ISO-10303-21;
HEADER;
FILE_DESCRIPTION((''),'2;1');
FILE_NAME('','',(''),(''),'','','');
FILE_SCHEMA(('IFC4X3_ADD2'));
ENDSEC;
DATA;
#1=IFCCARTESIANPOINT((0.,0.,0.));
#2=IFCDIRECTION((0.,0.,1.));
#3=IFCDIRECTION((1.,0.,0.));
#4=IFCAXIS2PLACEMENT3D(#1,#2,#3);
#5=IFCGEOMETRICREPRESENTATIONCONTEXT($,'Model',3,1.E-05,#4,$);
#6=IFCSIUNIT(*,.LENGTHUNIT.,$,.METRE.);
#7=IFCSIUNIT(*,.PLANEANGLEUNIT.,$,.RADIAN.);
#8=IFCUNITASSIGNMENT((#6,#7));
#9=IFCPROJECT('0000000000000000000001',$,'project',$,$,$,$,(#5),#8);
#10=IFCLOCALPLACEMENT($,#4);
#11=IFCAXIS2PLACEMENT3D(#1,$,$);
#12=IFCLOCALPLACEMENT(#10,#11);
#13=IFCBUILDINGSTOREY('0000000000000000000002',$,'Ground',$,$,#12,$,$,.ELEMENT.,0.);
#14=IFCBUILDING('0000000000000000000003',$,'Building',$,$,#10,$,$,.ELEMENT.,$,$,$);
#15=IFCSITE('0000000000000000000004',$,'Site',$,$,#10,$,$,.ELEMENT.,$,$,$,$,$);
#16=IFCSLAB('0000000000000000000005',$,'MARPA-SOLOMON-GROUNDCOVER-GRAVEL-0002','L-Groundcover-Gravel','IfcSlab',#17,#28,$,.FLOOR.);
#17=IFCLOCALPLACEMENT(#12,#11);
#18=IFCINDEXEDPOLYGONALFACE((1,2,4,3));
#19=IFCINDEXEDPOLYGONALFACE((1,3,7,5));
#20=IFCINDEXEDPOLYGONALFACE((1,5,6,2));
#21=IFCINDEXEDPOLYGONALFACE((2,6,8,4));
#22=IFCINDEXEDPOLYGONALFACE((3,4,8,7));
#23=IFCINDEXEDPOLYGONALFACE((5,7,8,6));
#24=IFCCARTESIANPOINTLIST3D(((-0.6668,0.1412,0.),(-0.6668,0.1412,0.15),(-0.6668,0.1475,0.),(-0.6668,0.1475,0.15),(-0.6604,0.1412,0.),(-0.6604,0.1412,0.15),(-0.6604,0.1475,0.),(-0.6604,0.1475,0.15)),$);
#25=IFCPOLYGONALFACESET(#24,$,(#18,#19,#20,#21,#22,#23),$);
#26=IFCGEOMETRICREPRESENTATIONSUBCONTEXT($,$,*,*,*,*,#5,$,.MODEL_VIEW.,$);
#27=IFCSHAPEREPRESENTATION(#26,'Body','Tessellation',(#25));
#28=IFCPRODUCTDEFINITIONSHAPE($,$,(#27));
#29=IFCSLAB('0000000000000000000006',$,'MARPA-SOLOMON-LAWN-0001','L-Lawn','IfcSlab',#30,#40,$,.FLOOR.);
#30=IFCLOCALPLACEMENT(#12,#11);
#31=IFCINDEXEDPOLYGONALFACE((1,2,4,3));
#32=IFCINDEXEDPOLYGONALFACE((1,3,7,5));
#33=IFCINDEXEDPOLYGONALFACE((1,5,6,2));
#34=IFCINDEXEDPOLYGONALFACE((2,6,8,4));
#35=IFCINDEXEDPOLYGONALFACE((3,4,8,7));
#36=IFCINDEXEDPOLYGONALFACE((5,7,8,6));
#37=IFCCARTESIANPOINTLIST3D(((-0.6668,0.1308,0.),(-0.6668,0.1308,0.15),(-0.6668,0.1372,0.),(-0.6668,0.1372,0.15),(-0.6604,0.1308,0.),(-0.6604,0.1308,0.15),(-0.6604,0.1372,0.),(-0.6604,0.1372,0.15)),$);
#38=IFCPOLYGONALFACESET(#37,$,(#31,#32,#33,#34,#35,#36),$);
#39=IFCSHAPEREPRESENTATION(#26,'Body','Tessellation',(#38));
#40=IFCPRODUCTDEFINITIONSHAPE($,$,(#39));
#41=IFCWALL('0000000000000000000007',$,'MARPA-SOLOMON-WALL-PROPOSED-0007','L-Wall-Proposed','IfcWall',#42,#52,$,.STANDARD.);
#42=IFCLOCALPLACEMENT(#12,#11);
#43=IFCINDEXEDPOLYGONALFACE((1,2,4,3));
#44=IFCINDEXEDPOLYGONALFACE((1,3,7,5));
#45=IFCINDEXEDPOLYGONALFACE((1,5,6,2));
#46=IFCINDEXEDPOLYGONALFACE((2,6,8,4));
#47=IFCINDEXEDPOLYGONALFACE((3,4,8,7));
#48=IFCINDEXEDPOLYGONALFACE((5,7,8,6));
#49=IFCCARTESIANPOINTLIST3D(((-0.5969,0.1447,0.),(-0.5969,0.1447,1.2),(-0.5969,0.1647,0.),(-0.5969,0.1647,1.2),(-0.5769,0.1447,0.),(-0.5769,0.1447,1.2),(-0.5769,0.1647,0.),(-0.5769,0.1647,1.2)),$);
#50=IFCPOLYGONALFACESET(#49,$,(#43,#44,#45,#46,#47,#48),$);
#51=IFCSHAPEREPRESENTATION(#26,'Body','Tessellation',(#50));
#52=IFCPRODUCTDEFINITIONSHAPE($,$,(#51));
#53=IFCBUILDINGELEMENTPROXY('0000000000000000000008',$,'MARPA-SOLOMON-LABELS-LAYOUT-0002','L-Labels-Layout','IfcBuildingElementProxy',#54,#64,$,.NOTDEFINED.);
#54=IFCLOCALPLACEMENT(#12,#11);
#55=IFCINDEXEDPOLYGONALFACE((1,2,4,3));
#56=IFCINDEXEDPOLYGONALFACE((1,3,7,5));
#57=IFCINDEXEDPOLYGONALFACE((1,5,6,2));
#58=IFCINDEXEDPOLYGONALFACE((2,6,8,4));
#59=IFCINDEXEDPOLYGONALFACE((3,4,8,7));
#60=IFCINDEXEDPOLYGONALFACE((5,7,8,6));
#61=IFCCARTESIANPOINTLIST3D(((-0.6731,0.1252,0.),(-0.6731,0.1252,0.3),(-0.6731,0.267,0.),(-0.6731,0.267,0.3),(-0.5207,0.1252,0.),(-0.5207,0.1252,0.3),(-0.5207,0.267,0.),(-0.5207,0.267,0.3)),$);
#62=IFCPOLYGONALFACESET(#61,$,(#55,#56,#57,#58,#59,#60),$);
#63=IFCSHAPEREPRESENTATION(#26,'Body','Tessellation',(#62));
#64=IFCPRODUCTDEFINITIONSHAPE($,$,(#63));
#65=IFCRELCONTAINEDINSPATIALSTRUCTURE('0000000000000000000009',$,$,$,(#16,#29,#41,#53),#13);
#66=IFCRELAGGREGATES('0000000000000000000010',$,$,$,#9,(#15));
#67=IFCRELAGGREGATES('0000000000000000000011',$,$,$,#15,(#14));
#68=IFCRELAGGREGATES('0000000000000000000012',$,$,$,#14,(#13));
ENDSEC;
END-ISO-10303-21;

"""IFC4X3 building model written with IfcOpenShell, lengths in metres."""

from ifc_helpers import new_model, si_unit, frame, frame_2d, origin, origin_with_axes, place, context, subcontext, project, spatial, polyline, rectangle, outline, extrude, element, save


model = new_model("IFC4X3")

# Units and contexts
model_context = context("Model", 3, precision=1e-05, world=origin_with_axes())
sub_context = subcontext(model_context, None, None, "MODEL_VIEW")
ifc_project = project(units=[si_unit("LENGTHUNIT", "METRE"), si_unit("PLANEANGLEUNIT", "RADIAN")], contexts=[model_context])

# Site, building, storey
placement = place(None, origin_with_axes())
site = spatial("IfcSite", under=ifc_project, at=placement, Name="Site", CompositionType="ELEMENT")
building = spatial("IfcBuilding", under=site, at=placement, Name="Building", CompositionType="ELEMENT")
storey_placement = place(placement, origin())
storey = spatial("IfcBuildingStorey", under=building, at=storey_placement, Name="Ground", CompositionType="ELEMENT", Elevation=0.0)

# Slabs
for number, where, name, description in (
    (1, (-0.6668, 0.1412, 0.0), "MARPA-SOLOMON-GROUNDCOVER-GRAVEL-0002", "L-Groundcover-Gravel"),
    (2, (-0.6668, 0.1308, 0.0), "MARPA-SOLOMON-LAWN-0001", "L-Lawn"),
):
    element("IfcSlab", number, at=place(storey_placement, frame(where)), inside=storey, Name=name, Description=description, ObjectType="IfcSlab", PredefinedType="FLOOR", context=sub_context, shape_type="SweptSolid", body=[
        extrude(outline(polyline([(0.0, 0.0063), (0.0063, 0.0063), (0.0063, 0.0), (0.0, 0.0), (0.0, 0.0063)])), origin(), (0.0, 0.0, 1.0), 0.15),
    ])

# Wall
for number, where, x_axis, name in (
    (3, (-0.5969, 0.1547, 0.0), (1.0, 0.0, 0.0), "MARPA-SOLOMON-WALL-PROPOSED-0007"),
):
    element("IfcWall", number, at=place(storey_placement, frame(where, x_axis=x_axis)), inside=storey, Name=name, Description="L-Wall-Proposed", ObjectType="IfcWall", PredefinedType="STANDARD", context=sub_context, shape_type="SweptSolid", body=[
        extrude(rectangle(XDim=0.02, YDim=0.02, at=frame_2d((0.01, 0.0))), origin(), (0.0, 0.0, 1.0), 1.2),
    ])

# Building element proxy
for number, where, name in (
    (4, (-0.6731, 0.1252, 0.0), "MARPA-SOLOMON-LABELS-LAYOUT-0002"),
):
    element("IfcBuildingElementProxy", number, at=place(placement, frame(where)), inside=storey, Name=name, Description="L-Labels-Layout", ObjectType="IfcBuildingElementProxy", PredefinedType="NOTDEFINED", context=sub_context, shape_type="SweptSolid", body=[
        extrude(outline(polyline([(0.0, 0.1418), (0.1524, 0.1418), (0.1524, 0.0), (0.0, 0.0), (0.0, 0.1418)])), origin(), (0.0, 0.0, 1.0), 0.3),
    ])

save(model, "model.ifc")
